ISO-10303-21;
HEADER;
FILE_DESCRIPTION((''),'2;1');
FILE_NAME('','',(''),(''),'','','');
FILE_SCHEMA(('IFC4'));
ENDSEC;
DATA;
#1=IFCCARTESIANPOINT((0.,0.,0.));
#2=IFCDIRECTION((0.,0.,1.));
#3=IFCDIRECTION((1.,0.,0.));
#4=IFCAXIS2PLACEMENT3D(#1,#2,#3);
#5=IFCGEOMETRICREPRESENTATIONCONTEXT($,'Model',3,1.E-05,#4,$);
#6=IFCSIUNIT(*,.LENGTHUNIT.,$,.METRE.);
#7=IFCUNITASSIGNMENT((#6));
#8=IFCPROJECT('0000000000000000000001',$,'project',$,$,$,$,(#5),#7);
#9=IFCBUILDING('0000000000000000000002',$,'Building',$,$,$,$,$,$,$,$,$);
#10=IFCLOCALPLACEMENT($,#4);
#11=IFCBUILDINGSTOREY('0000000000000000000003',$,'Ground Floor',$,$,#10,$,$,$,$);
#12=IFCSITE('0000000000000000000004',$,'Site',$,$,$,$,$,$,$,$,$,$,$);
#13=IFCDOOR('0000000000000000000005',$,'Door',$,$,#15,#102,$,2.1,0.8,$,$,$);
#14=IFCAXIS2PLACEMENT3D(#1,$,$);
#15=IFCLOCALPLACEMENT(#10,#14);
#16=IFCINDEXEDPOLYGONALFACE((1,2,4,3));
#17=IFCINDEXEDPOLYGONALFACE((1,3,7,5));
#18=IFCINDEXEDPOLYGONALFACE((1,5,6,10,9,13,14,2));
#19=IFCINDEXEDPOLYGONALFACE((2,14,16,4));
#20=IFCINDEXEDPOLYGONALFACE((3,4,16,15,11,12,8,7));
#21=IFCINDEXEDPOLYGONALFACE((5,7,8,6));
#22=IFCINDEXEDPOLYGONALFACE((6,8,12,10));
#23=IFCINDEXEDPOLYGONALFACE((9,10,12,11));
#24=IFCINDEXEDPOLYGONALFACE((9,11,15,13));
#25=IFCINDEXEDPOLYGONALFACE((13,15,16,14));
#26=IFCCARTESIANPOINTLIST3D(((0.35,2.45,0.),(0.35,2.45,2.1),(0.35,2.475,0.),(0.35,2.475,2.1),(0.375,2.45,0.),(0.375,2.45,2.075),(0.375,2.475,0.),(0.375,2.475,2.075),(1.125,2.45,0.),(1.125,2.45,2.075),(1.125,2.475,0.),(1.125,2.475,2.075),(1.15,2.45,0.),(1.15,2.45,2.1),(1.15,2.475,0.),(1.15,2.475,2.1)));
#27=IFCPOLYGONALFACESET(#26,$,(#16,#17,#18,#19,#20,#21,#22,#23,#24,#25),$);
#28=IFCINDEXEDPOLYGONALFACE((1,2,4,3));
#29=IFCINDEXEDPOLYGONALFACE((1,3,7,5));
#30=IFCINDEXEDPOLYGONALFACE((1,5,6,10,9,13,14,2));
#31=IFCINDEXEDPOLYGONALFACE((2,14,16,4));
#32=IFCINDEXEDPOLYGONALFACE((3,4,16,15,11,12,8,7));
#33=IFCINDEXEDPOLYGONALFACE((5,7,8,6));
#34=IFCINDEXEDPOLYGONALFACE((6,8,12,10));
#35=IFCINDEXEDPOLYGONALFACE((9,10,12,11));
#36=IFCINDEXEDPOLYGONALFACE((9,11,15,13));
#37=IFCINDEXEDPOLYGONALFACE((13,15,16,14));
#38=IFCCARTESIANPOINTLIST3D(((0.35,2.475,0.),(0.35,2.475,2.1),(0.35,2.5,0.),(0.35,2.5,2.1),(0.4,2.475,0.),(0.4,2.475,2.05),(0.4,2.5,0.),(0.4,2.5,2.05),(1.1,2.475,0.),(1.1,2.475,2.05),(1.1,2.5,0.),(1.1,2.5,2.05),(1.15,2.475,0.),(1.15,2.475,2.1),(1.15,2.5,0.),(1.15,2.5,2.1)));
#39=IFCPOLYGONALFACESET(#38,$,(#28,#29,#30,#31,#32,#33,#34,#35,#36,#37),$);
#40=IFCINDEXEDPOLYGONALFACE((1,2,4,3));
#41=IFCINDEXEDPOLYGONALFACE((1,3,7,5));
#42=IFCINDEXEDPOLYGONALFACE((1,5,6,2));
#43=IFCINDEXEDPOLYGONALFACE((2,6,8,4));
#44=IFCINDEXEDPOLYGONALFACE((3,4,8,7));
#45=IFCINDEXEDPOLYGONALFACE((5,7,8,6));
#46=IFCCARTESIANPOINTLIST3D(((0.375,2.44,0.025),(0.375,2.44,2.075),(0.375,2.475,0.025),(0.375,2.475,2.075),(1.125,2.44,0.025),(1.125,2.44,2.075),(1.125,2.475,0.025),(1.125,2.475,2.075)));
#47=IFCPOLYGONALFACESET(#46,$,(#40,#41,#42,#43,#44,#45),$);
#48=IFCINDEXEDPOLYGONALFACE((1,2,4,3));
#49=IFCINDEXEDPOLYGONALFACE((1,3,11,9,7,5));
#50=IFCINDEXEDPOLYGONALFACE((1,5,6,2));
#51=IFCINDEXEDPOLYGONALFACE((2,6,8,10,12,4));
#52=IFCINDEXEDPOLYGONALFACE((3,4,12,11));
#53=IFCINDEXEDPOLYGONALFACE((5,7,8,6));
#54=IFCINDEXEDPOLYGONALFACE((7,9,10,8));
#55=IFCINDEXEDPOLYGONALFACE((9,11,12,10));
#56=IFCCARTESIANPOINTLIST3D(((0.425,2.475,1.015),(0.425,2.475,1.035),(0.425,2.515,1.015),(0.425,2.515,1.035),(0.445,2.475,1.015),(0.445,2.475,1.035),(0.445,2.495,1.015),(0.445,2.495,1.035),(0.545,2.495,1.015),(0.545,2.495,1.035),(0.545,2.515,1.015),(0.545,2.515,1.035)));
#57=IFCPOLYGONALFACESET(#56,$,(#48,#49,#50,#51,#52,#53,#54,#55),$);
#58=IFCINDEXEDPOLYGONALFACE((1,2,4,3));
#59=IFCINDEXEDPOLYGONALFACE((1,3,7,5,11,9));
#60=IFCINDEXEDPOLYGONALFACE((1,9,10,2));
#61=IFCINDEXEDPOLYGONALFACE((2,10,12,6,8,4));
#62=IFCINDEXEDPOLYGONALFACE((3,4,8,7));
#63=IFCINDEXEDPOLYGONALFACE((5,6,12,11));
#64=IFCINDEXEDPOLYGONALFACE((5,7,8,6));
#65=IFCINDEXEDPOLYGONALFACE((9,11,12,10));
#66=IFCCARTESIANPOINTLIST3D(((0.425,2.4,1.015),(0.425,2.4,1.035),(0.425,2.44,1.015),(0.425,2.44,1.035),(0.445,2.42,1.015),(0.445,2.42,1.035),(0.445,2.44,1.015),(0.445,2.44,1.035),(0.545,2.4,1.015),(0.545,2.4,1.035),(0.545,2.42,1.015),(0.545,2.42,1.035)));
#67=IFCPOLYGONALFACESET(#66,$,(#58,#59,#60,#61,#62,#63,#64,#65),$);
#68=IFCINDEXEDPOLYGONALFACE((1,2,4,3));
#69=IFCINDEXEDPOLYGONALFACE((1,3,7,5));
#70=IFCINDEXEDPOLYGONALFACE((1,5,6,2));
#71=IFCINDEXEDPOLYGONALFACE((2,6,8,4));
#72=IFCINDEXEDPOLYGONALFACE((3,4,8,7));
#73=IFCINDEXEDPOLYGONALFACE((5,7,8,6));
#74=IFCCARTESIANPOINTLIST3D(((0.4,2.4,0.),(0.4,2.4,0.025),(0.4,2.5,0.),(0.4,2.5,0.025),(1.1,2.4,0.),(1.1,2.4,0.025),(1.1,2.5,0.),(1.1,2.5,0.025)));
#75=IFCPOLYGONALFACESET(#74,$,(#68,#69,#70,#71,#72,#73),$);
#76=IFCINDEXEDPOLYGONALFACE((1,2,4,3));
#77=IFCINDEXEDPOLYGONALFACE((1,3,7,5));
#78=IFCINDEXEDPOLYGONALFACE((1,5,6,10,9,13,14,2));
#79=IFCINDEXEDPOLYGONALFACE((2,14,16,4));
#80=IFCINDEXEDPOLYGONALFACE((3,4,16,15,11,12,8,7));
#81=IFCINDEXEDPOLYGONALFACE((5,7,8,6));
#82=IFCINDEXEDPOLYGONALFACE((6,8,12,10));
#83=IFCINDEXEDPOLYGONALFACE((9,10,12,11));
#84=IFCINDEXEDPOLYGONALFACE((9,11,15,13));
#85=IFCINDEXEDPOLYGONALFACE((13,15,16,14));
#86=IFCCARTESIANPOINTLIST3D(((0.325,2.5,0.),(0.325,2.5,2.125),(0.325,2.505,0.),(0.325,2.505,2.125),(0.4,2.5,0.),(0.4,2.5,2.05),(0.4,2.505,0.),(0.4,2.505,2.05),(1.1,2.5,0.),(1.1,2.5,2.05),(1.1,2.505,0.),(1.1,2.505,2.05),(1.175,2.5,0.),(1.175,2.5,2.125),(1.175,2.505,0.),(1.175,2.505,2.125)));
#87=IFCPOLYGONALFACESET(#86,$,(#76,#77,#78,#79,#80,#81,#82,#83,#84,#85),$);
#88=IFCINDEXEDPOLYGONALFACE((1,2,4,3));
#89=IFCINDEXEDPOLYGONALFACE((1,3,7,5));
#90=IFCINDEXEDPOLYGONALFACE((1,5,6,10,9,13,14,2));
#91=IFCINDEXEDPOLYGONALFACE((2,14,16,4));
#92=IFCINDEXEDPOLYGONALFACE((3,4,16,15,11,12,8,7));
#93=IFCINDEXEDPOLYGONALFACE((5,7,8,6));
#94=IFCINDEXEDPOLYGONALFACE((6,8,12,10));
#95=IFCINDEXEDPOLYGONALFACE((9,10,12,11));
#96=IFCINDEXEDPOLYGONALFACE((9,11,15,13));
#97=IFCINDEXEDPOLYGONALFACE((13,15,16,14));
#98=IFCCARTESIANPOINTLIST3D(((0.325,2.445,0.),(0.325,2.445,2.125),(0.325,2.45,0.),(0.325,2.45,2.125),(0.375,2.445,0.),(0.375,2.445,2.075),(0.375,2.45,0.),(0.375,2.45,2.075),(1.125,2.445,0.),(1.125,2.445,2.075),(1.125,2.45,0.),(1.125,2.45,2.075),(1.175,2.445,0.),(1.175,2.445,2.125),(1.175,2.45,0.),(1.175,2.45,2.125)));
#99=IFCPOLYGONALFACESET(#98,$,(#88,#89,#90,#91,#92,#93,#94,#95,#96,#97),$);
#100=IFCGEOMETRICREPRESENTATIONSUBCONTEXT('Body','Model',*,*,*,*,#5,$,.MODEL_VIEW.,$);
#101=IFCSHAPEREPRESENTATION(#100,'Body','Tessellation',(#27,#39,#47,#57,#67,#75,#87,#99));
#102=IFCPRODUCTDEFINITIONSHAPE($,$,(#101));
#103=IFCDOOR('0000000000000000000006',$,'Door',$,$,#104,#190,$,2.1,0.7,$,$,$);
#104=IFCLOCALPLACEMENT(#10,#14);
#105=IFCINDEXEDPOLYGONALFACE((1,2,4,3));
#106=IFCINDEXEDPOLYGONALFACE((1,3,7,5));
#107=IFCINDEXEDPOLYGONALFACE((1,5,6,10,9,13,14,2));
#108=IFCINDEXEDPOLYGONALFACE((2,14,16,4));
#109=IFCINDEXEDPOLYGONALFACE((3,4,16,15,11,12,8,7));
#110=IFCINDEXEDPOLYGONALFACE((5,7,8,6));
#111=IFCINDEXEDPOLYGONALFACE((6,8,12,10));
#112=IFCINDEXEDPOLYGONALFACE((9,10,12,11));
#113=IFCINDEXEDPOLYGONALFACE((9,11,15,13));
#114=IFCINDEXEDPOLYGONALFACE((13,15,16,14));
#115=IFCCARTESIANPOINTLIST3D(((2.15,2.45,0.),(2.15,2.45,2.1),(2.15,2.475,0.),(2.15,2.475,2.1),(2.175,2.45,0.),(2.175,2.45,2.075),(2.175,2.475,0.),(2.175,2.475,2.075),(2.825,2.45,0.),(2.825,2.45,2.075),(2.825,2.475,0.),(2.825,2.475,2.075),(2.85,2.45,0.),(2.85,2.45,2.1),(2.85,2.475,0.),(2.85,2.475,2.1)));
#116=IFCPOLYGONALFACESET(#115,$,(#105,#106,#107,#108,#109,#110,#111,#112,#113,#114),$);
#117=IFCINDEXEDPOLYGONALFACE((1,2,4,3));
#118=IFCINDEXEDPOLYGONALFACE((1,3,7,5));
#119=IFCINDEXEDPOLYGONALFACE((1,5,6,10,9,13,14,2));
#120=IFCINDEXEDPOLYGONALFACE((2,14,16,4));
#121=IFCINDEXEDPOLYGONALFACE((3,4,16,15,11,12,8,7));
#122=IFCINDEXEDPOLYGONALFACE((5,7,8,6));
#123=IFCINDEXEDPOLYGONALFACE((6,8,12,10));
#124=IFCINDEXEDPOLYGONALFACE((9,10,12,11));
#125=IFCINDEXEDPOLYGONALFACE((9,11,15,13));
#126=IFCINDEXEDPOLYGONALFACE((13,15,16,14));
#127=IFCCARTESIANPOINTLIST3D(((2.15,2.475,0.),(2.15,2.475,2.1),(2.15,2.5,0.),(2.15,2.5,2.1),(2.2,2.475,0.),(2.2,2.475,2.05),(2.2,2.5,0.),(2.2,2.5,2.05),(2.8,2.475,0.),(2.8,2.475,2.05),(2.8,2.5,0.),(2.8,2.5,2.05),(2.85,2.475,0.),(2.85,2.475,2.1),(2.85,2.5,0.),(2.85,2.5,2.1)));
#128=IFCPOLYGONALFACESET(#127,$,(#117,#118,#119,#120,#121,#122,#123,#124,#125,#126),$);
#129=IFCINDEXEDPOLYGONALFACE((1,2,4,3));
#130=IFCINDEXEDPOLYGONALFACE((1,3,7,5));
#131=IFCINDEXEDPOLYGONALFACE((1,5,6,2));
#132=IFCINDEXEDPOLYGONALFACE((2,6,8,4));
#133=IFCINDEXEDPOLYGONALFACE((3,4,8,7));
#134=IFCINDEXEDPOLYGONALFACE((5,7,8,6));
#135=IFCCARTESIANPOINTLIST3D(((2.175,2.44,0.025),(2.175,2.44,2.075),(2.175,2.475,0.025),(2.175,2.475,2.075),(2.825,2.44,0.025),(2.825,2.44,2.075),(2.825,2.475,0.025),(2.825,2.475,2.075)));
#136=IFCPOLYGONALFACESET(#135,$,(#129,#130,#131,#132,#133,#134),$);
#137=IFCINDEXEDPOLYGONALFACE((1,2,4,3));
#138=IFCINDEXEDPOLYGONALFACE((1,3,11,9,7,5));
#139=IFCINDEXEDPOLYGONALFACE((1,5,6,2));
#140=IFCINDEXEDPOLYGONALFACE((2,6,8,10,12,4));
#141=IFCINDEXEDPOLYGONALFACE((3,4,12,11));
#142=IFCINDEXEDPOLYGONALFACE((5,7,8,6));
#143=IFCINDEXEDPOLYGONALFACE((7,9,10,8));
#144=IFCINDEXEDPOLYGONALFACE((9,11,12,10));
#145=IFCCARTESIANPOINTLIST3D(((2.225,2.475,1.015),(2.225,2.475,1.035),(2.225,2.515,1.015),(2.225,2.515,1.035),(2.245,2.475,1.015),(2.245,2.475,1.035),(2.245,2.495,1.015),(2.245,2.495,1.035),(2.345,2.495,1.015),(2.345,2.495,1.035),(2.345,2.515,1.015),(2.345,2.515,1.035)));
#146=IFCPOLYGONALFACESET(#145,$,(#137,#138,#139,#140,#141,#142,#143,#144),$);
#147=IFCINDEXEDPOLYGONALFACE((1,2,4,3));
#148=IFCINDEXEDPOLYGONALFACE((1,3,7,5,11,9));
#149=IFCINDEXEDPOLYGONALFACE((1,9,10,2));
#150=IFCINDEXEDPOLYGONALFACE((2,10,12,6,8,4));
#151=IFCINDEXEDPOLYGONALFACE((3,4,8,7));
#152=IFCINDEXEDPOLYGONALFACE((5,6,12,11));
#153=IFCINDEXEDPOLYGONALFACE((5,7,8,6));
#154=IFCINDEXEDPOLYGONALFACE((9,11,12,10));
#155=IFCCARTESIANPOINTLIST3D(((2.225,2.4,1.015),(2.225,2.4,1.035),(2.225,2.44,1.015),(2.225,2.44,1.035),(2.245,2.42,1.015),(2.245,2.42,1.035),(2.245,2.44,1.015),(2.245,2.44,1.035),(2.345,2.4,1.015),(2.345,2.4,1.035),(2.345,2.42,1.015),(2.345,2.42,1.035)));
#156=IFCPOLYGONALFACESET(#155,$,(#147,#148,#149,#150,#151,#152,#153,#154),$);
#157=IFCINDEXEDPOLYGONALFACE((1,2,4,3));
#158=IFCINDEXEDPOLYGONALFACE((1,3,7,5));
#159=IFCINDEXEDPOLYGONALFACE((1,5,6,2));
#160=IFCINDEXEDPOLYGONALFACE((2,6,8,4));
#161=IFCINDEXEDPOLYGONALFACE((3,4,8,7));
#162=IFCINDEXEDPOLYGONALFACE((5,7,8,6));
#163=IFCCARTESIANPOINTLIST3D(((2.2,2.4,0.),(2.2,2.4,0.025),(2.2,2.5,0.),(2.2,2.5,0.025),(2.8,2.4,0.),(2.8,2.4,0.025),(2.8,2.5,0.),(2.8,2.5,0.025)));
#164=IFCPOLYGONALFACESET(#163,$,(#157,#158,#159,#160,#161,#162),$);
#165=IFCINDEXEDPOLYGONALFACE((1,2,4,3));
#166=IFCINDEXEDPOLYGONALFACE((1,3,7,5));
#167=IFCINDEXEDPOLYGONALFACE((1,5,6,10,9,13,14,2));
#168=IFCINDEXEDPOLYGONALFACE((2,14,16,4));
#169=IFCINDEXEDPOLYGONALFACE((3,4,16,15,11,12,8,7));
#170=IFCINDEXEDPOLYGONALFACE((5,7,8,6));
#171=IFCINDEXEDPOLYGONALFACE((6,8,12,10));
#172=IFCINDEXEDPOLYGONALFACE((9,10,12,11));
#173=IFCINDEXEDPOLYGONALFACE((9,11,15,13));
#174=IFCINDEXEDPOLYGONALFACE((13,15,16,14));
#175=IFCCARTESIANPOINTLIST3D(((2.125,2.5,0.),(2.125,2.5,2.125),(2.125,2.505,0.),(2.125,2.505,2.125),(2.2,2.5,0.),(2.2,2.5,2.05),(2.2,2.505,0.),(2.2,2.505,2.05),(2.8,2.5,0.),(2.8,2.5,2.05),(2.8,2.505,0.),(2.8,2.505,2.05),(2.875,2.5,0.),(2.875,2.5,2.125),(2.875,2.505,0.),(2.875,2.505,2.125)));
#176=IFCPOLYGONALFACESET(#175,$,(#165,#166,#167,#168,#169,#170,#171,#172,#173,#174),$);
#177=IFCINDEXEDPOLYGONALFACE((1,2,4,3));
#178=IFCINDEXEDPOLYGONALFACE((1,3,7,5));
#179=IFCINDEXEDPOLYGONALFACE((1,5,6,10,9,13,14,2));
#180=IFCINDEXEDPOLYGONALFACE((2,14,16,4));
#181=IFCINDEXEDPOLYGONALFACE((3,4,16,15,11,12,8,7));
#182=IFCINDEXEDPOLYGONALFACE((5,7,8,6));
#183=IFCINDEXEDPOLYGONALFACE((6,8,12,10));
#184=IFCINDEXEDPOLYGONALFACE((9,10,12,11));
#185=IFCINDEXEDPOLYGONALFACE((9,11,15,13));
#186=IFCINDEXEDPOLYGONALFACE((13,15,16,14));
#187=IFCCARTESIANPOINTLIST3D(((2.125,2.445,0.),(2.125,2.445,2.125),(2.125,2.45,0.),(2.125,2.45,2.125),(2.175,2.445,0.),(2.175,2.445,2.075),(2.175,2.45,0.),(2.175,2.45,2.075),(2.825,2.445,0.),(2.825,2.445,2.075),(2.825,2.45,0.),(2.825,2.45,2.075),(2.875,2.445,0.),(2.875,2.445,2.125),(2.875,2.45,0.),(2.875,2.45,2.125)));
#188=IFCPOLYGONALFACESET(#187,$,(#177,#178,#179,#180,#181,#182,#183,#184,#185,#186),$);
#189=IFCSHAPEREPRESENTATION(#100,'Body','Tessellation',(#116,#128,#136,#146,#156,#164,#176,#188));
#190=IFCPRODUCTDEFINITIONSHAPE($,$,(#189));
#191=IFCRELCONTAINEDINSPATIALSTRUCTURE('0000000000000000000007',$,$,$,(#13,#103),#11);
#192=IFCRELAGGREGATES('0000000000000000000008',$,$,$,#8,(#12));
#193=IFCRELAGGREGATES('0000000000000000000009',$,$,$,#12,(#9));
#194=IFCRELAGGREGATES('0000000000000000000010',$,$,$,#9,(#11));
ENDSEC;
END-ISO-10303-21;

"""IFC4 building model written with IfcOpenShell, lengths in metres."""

from ifc_helpers import new_model, si_unit, frame, origin_with_axes, place, context, subcontext, project, spatial, line, indexed_curve, outline, extrude, element, save


model = new_model("IFC4")

# Units and contexts
model_context = context("Model", 3, precision=1e-05, world=origin_with_axes())
body_context = subcontext(model_context, "Body", "Model", "MODEL_VIEW")
ifc_project = project(units=[si_unit("LENGTHUNIT", "METRE")], contexts=[model_context])

# Site, building, storey
site = spatial("IfcSite", under=ifc_project, Name="Site")
building = spatial("IfcBuilding", under=site, Name="Building")
storey_placement = place(None, origin_with_axes())
storey = spatial("IfcBuildingStorey", under=building, at=storey_placement, Name="Ground Floor")

# Doors
door_1_placement = place(storey_placement, frame((1.15, 2.5, 0.0), z_axis=(0.0, 0.0, 1.0), x_axis=(-1.0, 0.0, 0.0)))
element("IfcDoor", 1, at=door_1_placement, inside=storey, Name="Door", OverallHeight=2.1, OverallWidth=0.8, context=body_context, shape_type="SweptSolid", body=[
    extrude(outline(indexed_curve([(0.0, 0.0), (0.0, 2.1), (0.8, 2.1), (0.8, 0.0), (0.775, 0.0), (0.775, 2.075), (0.025, 2.075), (0.025, 0.0)], segments=[line(1, 2, 3, 4, 5, 6, 7, 8, 1)])), frame((0.0, 0.025, 0.0), z_axis=(0.0, -1.0, 0.0), x_axis=(1.0, 0.0, 0.0)), (0.0, 0.0, -1.0), 0.025),
    extrude(outline(indexed_curve([(0.0, 0.0), (0.0, 2.1), (0.8, 2.1), (0.8, 0.0), (0.75, 0.0), (0.75, 2.05), (0.05, 2.05), (0.05, 0.0)], segments=[line(1, 2, 3, 4, 5, 6, 7, 8, 1)])), frame((0.0, 0.0, 0.0), z_axis=(0.0, -1.0, 0.0), x_axis=(1.0, 0.0, 0.0)), (0.0, 0.0, -1.0), 0.025),
    extrude(outline(indexed_curve([(0.0, 0.0), (0.75, 0.0), (0.75, 0.035), (0.0, 0.035)], segments=[line(1, 2, 3, 4, 1)])), frame((0.025, 0.025, 0.025), z_axis=(0.0, 0.0, 1.0), x_axis=(1.0, 0.0, 0.0)), (0.0, 0.0, 1.0), 2.05),
    extrude(outline(indexed_curve([(0.0, 0.0), (0.0, -0.04), (-0.12, -0.04), (-0.12, -0.02), (-0.02, -0.02), (-0.02, 0.0)], segments=[line(1, 2, 3, 4, 5, 6, 1)])), frame((0.725, 0.025, 1.015), z_axis=(0.0, 0.0, 1.0), x_axis=(1.0, 0.0, 0.0)), (0.0, 0.0, 1.0), 0.02),
    extrude(outline(indexed_curve([(0.0, 0.0), (0.0, 0.04), (-0.12, 0.04), (-0.12, 0.02), (-0.02, 0.02), (-0.02, 0.0)], segments=[line(1, 2, 3, 4, 5, 6, 1)])), frame((0.725, 0.06, 1.015), z_axis=(0.0, 0.0, 1.0), x_axis=(1.0, 0.0, 0.0)), (0.0, 0.0, 1.0), 0.02),
    extrude(outline(indexed_curve([(0.0, 0.0), (0.7, 0.0), (0.7, 0.1), (0.0, 0.1)], segments=[line(1, 2, 3, 4, 1)])), frame((0.05, 0.0, 0.0), z_axis=(0.0, 0.0, 1.0), x_axis=(1.0, 0.0, 0.0)), (0.0, 0.0, 1.0), 0.025),
    extrude(outline(indexed_curve([(0.0, 0.0), (0.0, 2.125), (0.85, 2.125), (0.85, 0.0), (0.775, 0.0), (0.775, 2.05), (0.075, 2.05), (0.075, 0.0)], segments=[line(1, 2, 3, 4, 5, 6, 7, 8, 1)])), frame((-0.025, -0.005, 0.0), z_axis=(0.0, -1.0, 0.0), x_axis=(1.0, 0.0, 0.0)), (0.0, 0.0, -1.0), 0.005),
    extrude(outline(indexed_curve([(0.0, 0.0), (0.0, 2.125), (0.85, 2.125), (0.85, 0.0), (0.8, 0.0), (0.8, 2.075), (0.05, 2.075), (0.05, 0.0)], segments=[line(1, 2, 3, 4, 5, 6, 7, 8, 1)])), frame((-0.025, 0.05, 0.0), z_axis=(0.0, -1.0, 0.0), x_axis=(1.0, 0.0, 0.0)), (0.0, 0.0, -1.0), 0.005),
])
door_2_placement = place(storey_placement, frame((2.85, 2.5, 0.0), z_axis=(0.0, 0.0, 1.0), x_axis=(-1.0, 0.0, 0.0)))
element("IfcDoor", 2, at=door_2_placement, inside=storey, Name="Door", OverallHeight=2.1, OverallWidth=0.7, context=body_context, shape_type="SweptSolid", body=[
    extrude(outline(indexed_curve([(0.0, 0.0), (0.0, 2.1), (0.7, 2.1), (0.7, 0.0), (0.675, 0.0), (0.675, 2.075), (0.025, 2.075), (0.025, 0.0)], segments=[line(1, 2, 3, 4, 5, 6, 7, 8, 1)])), frame((0.0, 0.025, 0.0), z_axis=(0.0, -1.0, 0.0), x_axis=(1.0, 0.0, 0.0)), (0.0, 0.0, -1.0), 0.025),
    extrude(outline(indexed_curve([(0.0, 0.0), (0.0, 2.1), (0.7, 2.1), (0.7, 0.0), (0.65, 0.0), (0.65, 2.05), (0.05, 2.05), (0.05, 0.0)], segments=[line(1, 2, 3, 4, 5, 6, 7, 8, 1)])), frame((0.0, 0.0, 0.0), z_axis=(0.0, -1.0, 0.0), x_axis=(1.0, 0.0, 0.0)), (0.0, 0.0, -1.0), 0.025),
    extrude(outline(indexed_curve([(0.0, 0.0), (0.65, 0.0), (0.65, 0.035), (0.0, 0.035)], segments=[line(1, 2, 3, 4, 1)])), frame((0.025, 0.025, 0.025), z_axis=(0.0, 0.0, 1.0), x_axis=(1.0, 0.0, 0.0)), (0.0, 0.0, 1.0), 2.05),
    extrude(outline(indexed_curve([(0.0, 0.0), (0.0, -0.04), (-0.12, -0.04), (-0.12, -0.02), (-0.02, -0.02), (-0.02, 0.0)], segments=[line(1, 2, 3, 4, 5, 6, 1)])), frame((0.625, 0.025, 1.015), z_axis=(0.0, 0.0, 1.0), x_axis=(1.0, 0.0, 0.0)), (0.0, 0.0, 1.0), 0.02),
    extrude(outline(indexed_curve([(0.0, 0.0), (0.0, 0.04), (-0.12, 0.04), (-0.12, 0.02), (-0.02, 0.02), (-0.02, 0.0)], segments=[line(1, 2, 3, 4, 5, 6, 1)])), frame((0.625, 0.06, 1.015), z_axis=(0.0, 0.0, 1.0), x_axis=(1.0, 0.0, 0.0)), (0.0, 0.0, 1.0), 0.02),
    extrude(outline(indexed_curve([(0.0, 0.0), (0.6, 0.0), (0.6, 0.1), (0.0, 0.1)], segments=[line(1, 2, 3, 4, 1)])), frame((0.05, 0.0, 0.0), z_axis=(0.0, 0.0, 1.0), x_axis=(1.0, 0.0, 0.0)), (0.0, 0.0, 1.0), 0.025),
    extrude(outline(indexed_curve([(0.0, 0.0), (0.0, 2.125), (0.75, 2.125), (0.75, 0.0), (0.675, 0.0), (0.675, 2.05), (0.075, 2.05), (0.075, 0.0)], segments=[line(1, 2, 3, 4, 5, 6, 7, 8, 1)])), frame((-0.025, -0.005, 0.0), z_axis=(0.0, -1.0, 0.0), x_axis=(1.0, 0.0, 0.0)), (0.0, 0.0, -1.0), 0.005),
    extrude(outline(indexed_curve([(0.0, 0.0), (0.0, 2.125), (0.75, 2.125), (0.75, 0.0), (0.7, 0.0), (0.7, 2.075), (0.05, 2.075), (0.05, 0.0)], segments=[line(1, 2, 3, 4, 5, 6, 7, 8, 1)])), frame((-0.025, 0.05, 0.0), z_axis=(0.0, -1.0, 0.0), x_axis=(1.0, 0.0, 0.0)), (0.0, 0.0, -1.0), 0.005),
])

save(model, "model.ifc")
